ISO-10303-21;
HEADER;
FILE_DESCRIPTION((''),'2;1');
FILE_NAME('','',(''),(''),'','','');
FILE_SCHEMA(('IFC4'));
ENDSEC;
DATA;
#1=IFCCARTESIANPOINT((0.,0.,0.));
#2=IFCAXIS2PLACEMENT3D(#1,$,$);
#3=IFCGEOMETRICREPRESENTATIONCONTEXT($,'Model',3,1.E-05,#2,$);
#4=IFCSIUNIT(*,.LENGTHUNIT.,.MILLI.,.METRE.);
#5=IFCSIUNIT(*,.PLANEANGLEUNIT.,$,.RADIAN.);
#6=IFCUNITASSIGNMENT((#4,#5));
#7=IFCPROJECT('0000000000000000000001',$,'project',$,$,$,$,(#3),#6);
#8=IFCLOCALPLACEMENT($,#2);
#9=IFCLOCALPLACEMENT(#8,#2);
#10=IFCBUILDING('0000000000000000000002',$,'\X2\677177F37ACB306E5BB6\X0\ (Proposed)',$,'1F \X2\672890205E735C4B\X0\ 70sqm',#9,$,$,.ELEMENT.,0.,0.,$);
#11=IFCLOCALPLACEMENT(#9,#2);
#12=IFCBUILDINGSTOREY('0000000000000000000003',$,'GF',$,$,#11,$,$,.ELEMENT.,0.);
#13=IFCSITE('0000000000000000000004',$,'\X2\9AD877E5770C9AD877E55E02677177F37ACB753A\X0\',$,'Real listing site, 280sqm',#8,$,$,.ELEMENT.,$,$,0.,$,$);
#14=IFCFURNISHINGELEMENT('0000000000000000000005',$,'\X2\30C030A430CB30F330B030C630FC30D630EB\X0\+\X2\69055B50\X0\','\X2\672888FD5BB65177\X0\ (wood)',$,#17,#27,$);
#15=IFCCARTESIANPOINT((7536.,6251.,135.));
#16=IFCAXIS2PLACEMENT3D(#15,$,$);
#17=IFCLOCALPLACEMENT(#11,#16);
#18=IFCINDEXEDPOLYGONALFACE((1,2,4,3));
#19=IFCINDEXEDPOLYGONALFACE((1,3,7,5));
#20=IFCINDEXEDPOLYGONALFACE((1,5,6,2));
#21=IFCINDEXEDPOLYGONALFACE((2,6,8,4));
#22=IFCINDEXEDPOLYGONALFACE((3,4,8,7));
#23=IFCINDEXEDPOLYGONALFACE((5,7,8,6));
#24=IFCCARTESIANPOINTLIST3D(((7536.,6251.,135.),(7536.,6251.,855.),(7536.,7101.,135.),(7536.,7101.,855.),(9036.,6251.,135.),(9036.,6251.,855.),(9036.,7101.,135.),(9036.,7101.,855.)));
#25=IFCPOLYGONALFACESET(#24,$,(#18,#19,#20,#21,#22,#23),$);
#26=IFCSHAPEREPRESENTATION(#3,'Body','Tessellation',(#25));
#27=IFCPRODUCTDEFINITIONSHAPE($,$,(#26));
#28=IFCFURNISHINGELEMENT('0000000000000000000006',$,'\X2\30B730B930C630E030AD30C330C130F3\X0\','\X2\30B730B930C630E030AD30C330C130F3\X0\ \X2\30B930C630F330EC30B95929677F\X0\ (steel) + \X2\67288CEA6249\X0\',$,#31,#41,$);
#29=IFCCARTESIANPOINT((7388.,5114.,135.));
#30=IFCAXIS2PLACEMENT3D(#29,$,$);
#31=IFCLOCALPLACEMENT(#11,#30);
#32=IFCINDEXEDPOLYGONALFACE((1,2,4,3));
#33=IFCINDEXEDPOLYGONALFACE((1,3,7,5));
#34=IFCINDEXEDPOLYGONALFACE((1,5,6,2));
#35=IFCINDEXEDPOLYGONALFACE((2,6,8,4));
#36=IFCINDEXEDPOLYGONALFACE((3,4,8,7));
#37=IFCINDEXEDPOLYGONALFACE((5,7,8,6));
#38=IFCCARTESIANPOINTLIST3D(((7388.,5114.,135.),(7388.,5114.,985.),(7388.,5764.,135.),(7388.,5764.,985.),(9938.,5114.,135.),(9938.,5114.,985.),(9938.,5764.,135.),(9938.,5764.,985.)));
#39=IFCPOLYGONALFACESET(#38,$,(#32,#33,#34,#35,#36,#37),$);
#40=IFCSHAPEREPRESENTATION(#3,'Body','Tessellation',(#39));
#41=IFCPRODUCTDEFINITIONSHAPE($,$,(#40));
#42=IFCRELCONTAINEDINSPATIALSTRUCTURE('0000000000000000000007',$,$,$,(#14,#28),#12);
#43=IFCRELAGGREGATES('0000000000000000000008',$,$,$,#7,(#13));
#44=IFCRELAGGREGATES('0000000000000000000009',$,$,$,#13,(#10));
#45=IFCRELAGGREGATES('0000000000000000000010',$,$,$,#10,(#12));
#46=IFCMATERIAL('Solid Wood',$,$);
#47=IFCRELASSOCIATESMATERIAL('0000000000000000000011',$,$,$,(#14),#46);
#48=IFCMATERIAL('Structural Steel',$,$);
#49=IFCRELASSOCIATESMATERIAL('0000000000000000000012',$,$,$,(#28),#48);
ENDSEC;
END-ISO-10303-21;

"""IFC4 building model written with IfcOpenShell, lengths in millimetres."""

from ifc_helpers import new_model, si_unit, frame, frame_2d, origin, place, context, project, spatial, rectangle, extrude, material, element, save


model = new_model("IFC4")

# Units and contexts
model_context = context("Model", 3, precision=1e-05, world=origin())
ifc_project = project(units=[si_unit("LENGTHUNIT", "METRE", prefix="MILLI"), si_unit("PLANEANGLEUNIT", "RADIAN")], contexts=[model_context])

# Site, building, storey
site_placement = place(None, origin())
site = spatial("IfcSite", under=ifc_project, at=site_placement, Name="高知県高知市東石立町", ObjectType="Real listing site, 280sqm", CompositionType="ELEMENT", RefElevation=0.0)
building_placement = place(site_placement, origin())
building = spatial("IfcBuilding", under=site, at=building_placement, Name="東石立の家 (Proposed)", ObjectType="1F 木造平屋 70sqm", CompositionType="ELEMENT", ElevationOfRefHeight=0.0, ElevationOfTerrain=0.0)
storey_placement = place(building_placement, origin())
storey = spatial("IfcBuildingStorey", under=building, at=storey_placement, Name="GF", CompositionType="ELEMENT", Elevation=0.0)

# Shared definitions
ifc_material_1 = material(Name="Solid Wood")

# Shared definitions
ifc_material_2 = material(Name="Structural Steel")

# Furnishing elements
furnishing_1_placement = place(storey_placement, frame((7536.0, 6251.0, 135.0)))
element("IfcFurnishingElement", 1, at=furnishing_1_placement, inside=storey, material=ifc_material_1, Name="ダイニングテーブル+椅子", Description="木製家具 (wood)", context=model_context, shape_type="SweptSolid", body=[
    extrude(rectangle(XDim=1500.0, YDim=850.0, at=frame_2d((750.0, 425.0))), frame((7536.0, 6251.0, 135.0)), (0.0, 0.0, 1.0), 720.0),
])
furnishing_2_placement = place(storey_placement, frame((7388.0, 5114.0, 135.0)))
element("IfcFurnishingElement", 2, at=furnishing_2_placement, inside=storey, material=ifc_material_2, Name="システムキッチン", Description="システムキッチン ステンレス天板 (steel) + 木質扉", context=model_context, shape_type="SweptSolid", body=[
    extrude(rectangle(XDim=2550.0, YDim=650.0, at=frame_2d((1275.0, 325.0))), frame((7388.0, 5114.0, 135.0)), (0.0, 0.0, 1.0), 850.0),
])

save(model, "model.ifc")
